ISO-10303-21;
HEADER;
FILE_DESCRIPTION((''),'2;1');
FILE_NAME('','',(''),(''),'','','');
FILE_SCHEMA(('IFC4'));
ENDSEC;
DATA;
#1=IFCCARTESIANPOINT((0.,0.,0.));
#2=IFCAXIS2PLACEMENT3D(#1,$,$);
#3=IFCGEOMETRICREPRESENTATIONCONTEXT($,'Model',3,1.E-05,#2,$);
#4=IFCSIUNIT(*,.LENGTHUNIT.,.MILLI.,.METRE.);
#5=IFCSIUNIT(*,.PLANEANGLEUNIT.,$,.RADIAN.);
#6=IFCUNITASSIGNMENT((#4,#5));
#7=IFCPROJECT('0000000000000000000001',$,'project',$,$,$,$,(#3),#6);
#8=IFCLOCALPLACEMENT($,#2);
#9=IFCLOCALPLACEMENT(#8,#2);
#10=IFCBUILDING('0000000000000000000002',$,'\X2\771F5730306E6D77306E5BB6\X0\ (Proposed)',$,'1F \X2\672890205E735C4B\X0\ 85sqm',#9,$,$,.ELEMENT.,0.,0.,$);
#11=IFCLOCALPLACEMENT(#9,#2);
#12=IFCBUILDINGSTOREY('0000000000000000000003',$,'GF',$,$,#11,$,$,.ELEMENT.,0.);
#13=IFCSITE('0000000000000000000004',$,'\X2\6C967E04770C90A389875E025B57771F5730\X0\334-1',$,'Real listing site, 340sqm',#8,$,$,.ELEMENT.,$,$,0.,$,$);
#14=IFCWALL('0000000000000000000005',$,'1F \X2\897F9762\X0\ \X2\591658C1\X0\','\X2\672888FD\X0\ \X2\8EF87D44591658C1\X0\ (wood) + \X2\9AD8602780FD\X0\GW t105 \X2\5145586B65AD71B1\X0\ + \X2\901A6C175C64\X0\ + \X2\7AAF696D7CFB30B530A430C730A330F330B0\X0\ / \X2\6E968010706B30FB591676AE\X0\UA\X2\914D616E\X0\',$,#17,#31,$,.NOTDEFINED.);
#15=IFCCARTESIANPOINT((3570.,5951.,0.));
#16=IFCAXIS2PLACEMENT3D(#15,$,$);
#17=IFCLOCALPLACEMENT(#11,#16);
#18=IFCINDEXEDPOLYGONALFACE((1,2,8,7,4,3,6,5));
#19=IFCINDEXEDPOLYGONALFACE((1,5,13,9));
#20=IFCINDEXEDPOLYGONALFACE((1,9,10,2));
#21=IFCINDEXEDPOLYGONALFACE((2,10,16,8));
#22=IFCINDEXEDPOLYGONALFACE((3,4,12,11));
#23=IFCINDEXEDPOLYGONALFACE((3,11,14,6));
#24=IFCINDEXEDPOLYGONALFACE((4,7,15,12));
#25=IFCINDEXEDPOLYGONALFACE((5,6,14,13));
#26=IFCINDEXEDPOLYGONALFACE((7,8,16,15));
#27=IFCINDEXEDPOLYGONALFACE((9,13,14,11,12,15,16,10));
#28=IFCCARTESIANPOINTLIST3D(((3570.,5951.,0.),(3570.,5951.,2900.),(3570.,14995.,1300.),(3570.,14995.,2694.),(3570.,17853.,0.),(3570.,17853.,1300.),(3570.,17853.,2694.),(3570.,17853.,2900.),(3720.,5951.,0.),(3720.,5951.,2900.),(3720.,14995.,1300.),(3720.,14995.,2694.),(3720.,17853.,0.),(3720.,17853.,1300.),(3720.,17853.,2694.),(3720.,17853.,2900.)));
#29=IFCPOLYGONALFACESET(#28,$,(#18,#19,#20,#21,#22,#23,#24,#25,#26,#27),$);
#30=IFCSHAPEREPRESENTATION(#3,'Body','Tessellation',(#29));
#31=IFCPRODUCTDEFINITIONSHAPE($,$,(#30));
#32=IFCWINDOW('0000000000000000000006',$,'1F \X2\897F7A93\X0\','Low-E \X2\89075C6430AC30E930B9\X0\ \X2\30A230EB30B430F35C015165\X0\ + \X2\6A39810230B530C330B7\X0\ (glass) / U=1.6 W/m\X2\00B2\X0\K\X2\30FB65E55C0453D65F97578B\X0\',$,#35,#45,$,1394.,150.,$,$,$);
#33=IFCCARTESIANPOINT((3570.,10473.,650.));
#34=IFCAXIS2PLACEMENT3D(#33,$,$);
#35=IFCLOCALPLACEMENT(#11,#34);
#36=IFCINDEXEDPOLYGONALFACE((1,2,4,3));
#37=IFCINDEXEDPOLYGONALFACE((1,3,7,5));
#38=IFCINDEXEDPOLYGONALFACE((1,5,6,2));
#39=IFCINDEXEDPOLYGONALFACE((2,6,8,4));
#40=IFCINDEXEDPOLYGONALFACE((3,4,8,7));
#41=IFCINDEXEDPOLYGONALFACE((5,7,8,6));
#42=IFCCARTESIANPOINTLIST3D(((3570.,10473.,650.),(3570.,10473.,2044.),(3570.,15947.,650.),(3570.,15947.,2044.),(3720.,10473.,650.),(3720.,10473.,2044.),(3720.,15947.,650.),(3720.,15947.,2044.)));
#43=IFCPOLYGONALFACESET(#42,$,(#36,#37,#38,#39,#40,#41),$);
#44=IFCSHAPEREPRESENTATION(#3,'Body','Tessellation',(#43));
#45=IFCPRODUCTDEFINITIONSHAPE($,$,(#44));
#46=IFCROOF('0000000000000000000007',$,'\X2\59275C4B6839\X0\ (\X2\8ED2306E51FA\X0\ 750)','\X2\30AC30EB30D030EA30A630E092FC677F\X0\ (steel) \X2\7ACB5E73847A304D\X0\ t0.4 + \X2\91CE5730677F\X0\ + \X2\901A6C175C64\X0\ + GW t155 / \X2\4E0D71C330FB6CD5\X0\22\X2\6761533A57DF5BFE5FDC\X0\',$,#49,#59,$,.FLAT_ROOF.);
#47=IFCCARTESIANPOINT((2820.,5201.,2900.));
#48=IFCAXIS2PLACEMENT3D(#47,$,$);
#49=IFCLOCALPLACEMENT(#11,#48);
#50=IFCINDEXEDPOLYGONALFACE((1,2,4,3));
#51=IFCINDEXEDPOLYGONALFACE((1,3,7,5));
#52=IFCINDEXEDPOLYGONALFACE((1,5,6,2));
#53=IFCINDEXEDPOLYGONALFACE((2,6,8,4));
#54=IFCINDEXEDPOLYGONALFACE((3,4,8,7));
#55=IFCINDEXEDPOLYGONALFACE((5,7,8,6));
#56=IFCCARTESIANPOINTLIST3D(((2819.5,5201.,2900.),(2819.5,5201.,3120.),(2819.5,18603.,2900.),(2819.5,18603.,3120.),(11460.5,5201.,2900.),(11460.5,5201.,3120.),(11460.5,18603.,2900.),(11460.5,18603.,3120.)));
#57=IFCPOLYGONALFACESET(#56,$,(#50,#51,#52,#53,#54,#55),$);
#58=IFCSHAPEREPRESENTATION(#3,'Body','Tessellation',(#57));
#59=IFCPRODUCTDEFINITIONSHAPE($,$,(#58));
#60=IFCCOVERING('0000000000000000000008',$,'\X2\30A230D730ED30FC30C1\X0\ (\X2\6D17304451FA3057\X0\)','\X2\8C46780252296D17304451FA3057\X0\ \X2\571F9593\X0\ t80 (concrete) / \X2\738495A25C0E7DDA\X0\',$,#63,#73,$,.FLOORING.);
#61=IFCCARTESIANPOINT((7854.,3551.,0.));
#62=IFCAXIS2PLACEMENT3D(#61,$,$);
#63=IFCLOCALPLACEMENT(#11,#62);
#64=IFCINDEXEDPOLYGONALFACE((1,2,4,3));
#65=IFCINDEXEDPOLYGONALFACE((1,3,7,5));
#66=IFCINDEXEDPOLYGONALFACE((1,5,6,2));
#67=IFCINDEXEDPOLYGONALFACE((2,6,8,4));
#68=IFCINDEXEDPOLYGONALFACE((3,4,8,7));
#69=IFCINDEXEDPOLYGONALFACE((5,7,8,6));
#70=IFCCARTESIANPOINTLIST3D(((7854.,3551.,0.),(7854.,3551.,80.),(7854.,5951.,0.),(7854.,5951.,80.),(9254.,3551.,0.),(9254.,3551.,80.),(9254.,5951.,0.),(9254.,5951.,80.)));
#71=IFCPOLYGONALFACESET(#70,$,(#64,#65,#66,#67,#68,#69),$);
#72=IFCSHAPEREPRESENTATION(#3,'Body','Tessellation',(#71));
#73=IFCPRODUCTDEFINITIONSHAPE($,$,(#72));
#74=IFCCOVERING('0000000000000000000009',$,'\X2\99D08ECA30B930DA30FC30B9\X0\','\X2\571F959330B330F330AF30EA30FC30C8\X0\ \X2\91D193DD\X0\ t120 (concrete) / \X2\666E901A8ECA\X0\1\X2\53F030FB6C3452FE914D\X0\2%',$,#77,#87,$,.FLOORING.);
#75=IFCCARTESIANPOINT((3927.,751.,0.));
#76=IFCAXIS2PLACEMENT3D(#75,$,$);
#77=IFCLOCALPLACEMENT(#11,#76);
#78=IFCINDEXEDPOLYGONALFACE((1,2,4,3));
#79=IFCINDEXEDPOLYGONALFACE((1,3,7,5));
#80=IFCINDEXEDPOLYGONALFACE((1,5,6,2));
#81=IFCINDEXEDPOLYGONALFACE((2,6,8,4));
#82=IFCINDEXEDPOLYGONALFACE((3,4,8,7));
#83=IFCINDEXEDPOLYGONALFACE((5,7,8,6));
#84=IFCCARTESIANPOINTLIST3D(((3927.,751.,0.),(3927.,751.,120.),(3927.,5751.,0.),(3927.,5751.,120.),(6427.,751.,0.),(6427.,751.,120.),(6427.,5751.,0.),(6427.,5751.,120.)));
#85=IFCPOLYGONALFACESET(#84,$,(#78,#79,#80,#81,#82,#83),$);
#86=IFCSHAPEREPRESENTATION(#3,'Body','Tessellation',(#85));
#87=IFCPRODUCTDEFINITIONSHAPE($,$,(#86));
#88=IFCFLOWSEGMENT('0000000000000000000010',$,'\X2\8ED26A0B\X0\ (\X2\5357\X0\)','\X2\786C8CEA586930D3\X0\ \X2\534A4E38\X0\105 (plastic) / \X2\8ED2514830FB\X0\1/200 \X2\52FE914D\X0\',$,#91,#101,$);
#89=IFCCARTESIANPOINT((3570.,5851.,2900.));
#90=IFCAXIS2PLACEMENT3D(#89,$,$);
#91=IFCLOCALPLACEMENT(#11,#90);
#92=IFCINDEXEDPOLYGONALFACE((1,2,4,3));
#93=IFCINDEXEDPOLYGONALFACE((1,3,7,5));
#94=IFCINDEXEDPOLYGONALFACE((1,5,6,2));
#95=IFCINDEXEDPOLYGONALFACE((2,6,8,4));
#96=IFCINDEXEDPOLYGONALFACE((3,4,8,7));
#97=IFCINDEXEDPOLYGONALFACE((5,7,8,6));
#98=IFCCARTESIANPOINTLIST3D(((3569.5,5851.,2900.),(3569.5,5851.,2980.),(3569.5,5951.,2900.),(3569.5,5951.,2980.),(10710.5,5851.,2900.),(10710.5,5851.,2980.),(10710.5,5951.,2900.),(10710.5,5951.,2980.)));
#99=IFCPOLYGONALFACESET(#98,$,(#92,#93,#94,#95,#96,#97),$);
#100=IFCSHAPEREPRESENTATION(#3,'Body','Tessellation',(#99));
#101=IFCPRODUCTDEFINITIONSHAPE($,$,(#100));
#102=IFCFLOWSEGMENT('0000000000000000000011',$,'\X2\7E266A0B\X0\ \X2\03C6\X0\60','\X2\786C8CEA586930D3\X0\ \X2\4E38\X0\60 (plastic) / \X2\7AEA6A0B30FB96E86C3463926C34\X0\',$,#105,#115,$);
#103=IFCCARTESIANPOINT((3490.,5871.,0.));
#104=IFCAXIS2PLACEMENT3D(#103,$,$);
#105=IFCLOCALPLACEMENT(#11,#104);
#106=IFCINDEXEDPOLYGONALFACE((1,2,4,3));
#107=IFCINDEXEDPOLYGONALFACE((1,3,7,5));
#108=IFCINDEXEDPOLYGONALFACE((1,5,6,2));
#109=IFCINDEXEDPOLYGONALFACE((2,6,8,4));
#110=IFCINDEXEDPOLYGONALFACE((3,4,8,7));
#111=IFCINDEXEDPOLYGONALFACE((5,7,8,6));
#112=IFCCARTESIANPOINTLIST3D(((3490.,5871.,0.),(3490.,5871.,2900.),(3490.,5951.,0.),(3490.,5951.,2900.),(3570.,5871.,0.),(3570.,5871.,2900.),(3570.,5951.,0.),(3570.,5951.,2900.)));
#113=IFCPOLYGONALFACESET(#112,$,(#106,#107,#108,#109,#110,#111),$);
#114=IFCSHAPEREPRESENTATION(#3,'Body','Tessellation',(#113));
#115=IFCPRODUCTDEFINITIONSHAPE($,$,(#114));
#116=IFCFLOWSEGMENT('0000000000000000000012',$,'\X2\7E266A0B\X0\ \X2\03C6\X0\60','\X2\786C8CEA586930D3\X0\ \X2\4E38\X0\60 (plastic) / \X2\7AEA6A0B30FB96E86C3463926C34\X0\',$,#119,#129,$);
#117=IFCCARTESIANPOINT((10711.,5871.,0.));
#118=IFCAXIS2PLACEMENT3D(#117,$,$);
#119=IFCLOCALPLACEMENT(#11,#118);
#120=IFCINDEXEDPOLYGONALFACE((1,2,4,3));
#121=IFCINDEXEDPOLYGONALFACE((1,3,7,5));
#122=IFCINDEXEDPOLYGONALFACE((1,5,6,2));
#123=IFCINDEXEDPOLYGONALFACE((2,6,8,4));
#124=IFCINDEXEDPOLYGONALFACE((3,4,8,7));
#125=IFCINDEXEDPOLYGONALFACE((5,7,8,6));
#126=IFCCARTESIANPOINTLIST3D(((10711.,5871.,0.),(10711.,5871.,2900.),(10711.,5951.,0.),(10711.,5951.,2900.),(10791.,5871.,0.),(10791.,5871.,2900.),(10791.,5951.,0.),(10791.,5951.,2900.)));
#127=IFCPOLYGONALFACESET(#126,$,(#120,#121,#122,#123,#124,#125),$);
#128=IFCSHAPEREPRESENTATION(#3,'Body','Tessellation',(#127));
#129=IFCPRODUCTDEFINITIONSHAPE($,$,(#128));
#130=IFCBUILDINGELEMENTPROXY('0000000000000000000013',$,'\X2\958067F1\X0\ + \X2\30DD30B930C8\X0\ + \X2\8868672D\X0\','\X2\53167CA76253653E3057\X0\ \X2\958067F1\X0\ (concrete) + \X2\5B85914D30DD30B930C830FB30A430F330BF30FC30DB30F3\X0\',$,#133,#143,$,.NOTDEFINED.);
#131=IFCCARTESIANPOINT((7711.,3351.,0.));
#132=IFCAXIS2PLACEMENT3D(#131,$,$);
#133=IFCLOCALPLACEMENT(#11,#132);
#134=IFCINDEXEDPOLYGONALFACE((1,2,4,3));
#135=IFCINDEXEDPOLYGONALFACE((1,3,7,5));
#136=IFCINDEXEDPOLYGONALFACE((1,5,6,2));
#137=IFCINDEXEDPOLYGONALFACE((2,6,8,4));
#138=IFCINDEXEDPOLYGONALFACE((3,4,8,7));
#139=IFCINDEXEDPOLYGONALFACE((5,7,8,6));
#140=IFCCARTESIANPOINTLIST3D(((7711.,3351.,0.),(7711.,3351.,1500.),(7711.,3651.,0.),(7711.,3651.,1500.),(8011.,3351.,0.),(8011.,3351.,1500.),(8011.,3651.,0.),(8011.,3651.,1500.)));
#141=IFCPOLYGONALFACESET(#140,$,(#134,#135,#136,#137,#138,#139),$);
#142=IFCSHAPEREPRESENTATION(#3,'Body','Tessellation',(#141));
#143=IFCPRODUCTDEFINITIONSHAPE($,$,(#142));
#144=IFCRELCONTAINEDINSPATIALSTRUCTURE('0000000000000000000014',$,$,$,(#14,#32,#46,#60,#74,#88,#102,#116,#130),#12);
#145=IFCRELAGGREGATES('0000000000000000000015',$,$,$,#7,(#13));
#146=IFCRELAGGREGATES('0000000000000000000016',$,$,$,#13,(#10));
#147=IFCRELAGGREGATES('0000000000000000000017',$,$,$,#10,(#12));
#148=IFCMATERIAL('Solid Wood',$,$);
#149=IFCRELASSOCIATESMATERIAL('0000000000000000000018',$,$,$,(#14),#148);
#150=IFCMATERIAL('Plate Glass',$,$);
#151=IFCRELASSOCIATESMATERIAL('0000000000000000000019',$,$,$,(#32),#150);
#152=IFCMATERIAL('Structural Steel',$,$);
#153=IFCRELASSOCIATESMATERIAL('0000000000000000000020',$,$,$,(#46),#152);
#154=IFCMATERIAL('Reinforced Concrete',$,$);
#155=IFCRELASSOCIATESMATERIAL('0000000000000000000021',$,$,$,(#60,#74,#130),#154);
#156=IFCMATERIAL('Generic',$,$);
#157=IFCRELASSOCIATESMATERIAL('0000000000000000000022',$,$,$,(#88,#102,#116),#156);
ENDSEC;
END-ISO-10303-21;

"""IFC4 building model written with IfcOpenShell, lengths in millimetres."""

from ifc_helpers import new_model, si_unit, frame, frame_2d, origin, place, context, project, spatial, rectangle, extrude, material, element, fill, save


model = new_model("IFC4")

# Units and contexts
model_context = context("Model", 3, precision=1e-05, world=origin())
ifc_project = project(units=[si_unit("LENGTHUNIT", "METRE", prefix="MILLI"), si_unit("PLANEANGLEUNIT", "RADIAN")], contexts=[model_context])

# Site, building, storey
site_placement = place(None, origin())
site = spatial("IfcSite", under=ifc_project, at=site_placement, Name="沖縄県那覇市字真地334-1", ObjectType="Real listing site, 340sqm", CompositionType="ELEMENT", RefElevation=0.0)
building_placement = place(site_placement, origin())
building = spatial("IfcBuilding", under=site, at=building_placement, Name="真地の海の家 (Proposed)", ObjectType="1F 木造平屋 85sqm", CompositionType="ELEMENT", ElevationOfRefHeight=0.0, ElevationOfTerrain=0.0)
storey_placement = place(building_placement, origin())
storey = spatial("IfcBuildingStorey", under=building, at=storey_placement, Name="GF", CompositionType="ELEMENT", Elevation=0.0)

# Shared definitions
ifc_material_1 = material(Name="Solid Wood")

# Shared definitions
ifc_material_2 = material(Name="Reinforced Concrete")

# Shared definitions
ifc_material_3 = material(Name="Plate Glass")

# Wall, opening, window
wall_1_placement = place(storey_placement, frame((3570.0, 5951.0, 0.0)))
wall_1 = element("IfcWall", 1, at=wall_1_placement, inside=storey, material=ifc_material_1, Name="1F 西面 外壁", Description="木製 軸組外壁 (wood) + 高性能GW t105 充填断熱 + 通気層 + 窯業系サイディング / 準耐火・外皮UA配慮", PredefinedType="NOTDEFINED", context=model_context, shape_type="SweptSolid", body=[
    extrude(rectangle(XDim=150.0, YDim=11902.0, at=frame_2d((75.0, 5951.0))), frame((3570.0, 5951.0, 0.0)), (0.0, 0.0, 1.0), 2900.0),
])
opening_1_placement = place(storey_placement, frame((3570.0, 10473.0, 650.0)))
opening_1 = element("IfcOpeningElement", 2, at=opening_1_placement, cuts=wall_1, PredefinedType="NOTDEFINED", context=model_context, shape_type="SweptSolid", body=[
    extrude(rectangle(XDim=150.0, YDim=5474.0, at=frame_2d((75.0, 2737.0))), frame((3570.0, 10473.0, 650.0)), (0.0, 0.0, 1.0), 1394.0),
])
window_1_placement = place(storey_placement, frame((3570.0, 10473.0, 650.0)))
window_1 = element("IfcWindow", 3, at=window_1_placement, inside=storey, material=ifc_material_3, Name="1F 西窓", Description="Low-E 複層ガラス アルゴン封入 + 樹脂サッシ (glass) / U=1.6 W/m²K・日射取得型", OverallHeight=1394.0, OverallWidth=150.0, context=model_context, shape_type="SweptSolid", body=[
    extrude(rectangle(XDim=150.0, YDim=5474.0, at=frame_2d((75.0, 2737.0))), frame((3570.0, 10473.0, 650.0)), (0.0, 0.0, 1.0), 1394.0),
])
fill(opening_1, window_1)

# Roof
ifc_material_4 = material(Name="Structural Steel")
roof_placement = place(storey_placement, frame((2820.0, 5201.0, 2900.0)))
element("IfcRoof", 4, at=roof_placement, inside=storey, material=ifc_material_4, Name="大屋根 (軒の出 750)", Description="ガルバリウム鋼板 (steel) 立平葺き t0.4 + 野地板 + 通気層 + GW t155 / 不燃・法22条区域対応", PredefinedType="FLAT_ROOF", context=model_context, shape_type="SweptSolid", body=[
    extrude(rectangle(XDim=8641.0, YDim=13402.0, at=frame_2d((4320.0, 6701.0))), frame((2820.0, 5201.0, 2900.0)), (0.0, 0.0, 1.0), 220.0),
])

# Coverings
covering_1_placement = place(storey_placement, frame((7854.0, 3551.0, 0.0)))
element("IfcCovering", 5, at=covering_1_placement, inside=storey, material=ifc_material_2, Name="アプローチ (洗い出し)", Description="豆砂利洗い出し 土間 t80 (concrete) / 玄関導線", PredefinedType="FLOORING", context=model_context, shape_type="SweptSolid", body=[
    extrude(rectangle(XDim=1400.0, YDim=2400.0, at=frame_2d((700.0, 1200.0))), frame((7854.0, 3551.0, 0.0)), (0.0, 0.0, 1.0), 80.0),
])
covering_2_placement = place(storey_placement, frame((3927.0, 751.0, 0.0)))
element("IfcCovering", 6, at=covering_2_placement, inside=storey, material=ifc_material_2, Name="駐車スペース", Description="土間コンクリート 金鏝 t120 (concrete) / 普通車1台・水勾配2%", PredefinedType="FLOORING", context=model_context, shape_type="SweptSolid", body=[
    extrude(rectangle(XDim=2500.0, YDim=5000.0, at=frame_2d((1250.0, 2500.0))), frame((3927.0, 751.0, 0.0)), (0.0, 0.0, 1.0), 120.0),
])

# Flow segments
ifc_material_5 = material(Name="Generic")
flow_segment_1_placement = place(storey_placement, frame((3570.0, 5851.0, 2900.0)))
element("IfcFlowSegment", 7, at=flow_segment_1_placement, inside=storey, material=ifc_material_5, Name="軒樋 (南)", Description="硬質塩ビ 半丸105 (plastic) / 軒先・1/200 勾配", context=model_context, shape_type="SweptSolid", body=[
    extrude(rectangle(XDim=7141.0, YDim=100.0, at=frame_2d((3570.0, 50.0))), frame((3570.0, 5851.0, 2900.0)), (0.0, 0.0, 1.0), 80.0),
])
flow_segment_2_placement = place(storey_placement, frame((3490.0, 5871.0, 0.0)))
element("IfcFlowSegment", 8, at=flow_segment_2_placement, inside=storey, material=ifc_material_5, Name="縦樋 φ60", Description="硬質塩ビ 丸60 (plastic) / 竪樋・雨水排水", context=model_context, shape_type="SweptSolid", body=[
    extrude(rectangle(XDim=80.0, YDim=80.0, at=frame_2d((40.0, 40.0))), frame((3490.0, 5871.0, 0.0)), (0.0, 0.0, 1.0), 2900.0),
])
flow_segment_3_placement = place(storey_placement, frame((10711.0, 5871.0, 0.0)))
element("IfcFlowSegment", 9, at=flow_segment_3_placement, inside=storey, material=ifc_material_5, Name="縦樋 φ60", Description="硬質塩ビ 丸60 (plastic) / 竪樋・雨水排水", context=model_context, shape_type="SweptSolid", body=[
    extrude(rectangle(XDim=80.0, YDim=80.0, at=frame_2d((40.0, 40.0))), frame((10711.0, 5871.0, 0.0)), (0.0, 0.0, 1.0), 2900.0),
])

# Building element proxy
proxy_placement = place(storey_placement, frame((7711.0, 3351.0, 0.0)))
element("IfcBuildingElementProxy", 10, at=proxy_placement, inside=storey, material=ifc_material_2, Name="門柱 + ポスト + 表札", Description="化粧打放し 門柱 (concrete) + 宅配ポスト・インターホン", PredefinedType="NOTDEFINED", context=model_context, shape_type="SweptSolid", body=[
    extrude(rectangle(XDim=300.0, YDim=300.0, at=frame_2d((150.0, 150.0))), frame((7711.0, 3351.0, 0.0)), (0.0, 0.0, 1.0), 1500.0),
])

save(model, "model.ifc")
